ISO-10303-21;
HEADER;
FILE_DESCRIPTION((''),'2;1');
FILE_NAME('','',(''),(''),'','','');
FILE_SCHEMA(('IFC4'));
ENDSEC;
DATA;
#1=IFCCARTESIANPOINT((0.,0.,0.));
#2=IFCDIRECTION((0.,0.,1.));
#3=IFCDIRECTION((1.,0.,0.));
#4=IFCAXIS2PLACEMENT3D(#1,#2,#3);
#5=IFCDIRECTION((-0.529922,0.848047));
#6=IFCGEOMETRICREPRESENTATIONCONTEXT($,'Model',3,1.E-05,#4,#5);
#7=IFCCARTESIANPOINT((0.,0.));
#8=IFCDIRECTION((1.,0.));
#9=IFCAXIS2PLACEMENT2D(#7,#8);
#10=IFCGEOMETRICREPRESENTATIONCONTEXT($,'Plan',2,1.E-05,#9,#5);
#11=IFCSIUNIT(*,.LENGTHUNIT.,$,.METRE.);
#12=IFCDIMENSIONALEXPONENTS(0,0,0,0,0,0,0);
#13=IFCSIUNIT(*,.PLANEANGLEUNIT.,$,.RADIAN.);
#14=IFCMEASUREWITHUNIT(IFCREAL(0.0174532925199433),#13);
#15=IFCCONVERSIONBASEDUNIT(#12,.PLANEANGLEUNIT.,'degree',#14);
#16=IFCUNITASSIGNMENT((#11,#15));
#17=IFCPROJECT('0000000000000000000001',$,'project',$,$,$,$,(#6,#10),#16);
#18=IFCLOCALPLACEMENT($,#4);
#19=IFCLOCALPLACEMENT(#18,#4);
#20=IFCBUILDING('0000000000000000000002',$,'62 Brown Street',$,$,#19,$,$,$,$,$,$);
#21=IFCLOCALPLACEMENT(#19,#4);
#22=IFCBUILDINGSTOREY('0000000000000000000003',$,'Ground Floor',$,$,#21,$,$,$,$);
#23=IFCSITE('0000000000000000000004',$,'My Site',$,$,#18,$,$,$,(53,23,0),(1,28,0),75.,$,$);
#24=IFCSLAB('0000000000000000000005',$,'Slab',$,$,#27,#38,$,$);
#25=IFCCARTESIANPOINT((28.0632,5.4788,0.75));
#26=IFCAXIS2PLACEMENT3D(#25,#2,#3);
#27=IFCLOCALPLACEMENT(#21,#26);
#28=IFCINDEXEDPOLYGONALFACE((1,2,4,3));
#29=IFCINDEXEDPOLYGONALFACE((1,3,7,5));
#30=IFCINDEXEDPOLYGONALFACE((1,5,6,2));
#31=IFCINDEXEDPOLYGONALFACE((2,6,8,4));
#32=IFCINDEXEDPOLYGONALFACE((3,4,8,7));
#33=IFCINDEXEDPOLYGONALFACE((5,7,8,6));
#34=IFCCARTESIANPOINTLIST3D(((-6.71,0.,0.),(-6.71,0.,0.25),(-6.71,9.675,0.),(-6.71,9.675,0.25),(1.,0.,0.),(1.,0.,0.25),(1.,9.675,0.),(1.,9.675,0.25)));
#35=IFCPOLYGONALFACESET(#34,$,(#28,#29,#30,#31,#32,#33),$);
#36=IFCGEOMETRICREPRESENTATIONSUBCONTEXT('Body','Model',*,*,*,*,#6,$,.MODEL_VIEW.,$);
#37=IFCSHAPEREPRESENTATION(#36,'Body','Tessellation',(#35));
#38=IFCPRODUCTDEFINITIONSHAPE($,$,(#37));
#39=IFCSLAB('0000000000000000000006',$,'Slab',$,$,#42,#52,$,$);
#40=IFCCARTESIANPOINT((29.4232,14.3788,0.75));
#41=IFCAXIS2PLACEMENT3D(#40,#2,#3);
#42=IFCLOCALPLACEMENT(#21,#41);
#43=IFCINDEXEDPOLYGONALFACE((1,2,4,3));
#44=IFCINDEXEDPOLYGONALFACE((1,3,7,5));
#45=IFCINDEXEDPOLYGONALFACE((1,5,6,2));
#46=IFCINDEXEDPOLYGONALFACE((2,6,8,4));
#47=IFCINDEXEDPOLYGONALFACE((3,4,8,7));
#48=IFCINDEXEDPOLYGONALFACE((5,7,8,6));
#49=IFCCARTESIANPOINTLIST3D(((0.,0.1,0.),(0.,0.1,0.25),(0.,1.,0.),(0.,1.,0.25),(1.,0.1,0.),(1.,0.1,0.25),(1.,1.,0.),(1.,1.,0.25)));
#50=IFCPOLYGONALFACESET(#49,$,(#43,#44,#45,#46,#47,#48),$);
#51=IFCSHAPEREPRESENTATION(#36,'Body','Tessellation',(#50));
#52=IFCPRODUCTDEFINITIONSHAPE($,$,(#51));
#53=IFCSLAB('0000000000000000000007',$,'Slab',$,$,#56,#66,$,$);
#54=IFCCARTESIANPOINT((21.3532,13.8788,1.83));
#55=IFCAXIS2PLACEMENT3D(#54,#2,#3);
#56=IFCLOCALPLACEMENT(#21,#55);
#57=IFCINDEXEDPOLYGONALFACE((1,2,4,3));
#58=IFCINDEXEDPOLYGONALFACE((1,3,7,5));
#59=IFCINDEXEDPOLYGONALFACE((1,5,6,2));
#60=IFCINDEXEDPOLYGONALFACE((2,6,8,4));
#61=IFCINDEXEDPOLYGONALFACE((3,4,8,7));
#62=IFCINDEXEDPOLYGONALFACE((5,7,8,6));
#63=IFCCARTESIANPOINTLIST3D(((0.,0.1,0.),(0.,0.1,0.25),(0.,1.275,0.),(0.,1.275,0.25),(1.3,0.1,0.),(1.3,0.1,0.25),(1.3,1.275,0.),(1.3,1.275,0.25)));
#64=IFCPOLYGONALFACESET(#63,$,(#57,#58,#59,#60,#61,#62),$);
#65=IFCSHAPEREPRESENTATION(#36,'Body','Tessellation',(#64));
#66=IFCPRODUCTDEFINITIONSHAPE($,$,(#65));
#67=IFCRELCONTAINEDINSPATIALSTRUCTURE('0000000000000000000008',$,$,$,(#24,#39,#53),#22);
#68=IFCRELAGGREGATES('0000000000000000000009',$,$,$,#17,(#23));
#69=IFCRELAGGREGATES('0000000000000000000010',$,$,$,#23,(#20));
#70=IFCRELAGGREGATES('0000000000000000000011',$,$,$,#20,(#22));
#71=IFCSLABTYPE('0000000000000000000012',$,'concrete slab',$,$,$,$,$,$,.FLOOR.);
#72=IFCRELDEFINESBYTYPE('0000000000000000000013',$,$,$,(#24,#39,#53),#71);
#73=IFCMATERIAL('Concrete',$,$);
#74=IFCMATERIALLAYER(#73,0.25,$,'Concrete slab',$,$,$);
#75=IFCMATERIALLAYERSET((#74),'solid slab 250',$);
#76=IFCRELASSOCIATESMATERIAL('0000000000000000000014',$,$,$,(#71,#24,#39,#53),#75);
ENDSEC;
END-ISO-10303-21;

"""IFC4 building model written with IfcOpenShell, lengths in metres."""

from ifc_helpers import new_model, entity, si_unit, converted_unit, direction, frame, origin_with_axes, origin_2d_with_axis, place, context, subcontext, project, spatial, line, indexed_curve, outline, extrude, material, layer, layer_set, layer_usage, type_object, element, save


model = new_model("IFC4")

# Units and contexts
model_context = context("Model", 3, precision=1e-05, world=origin_with_axes(), true_north=direction((-0.529922, 0.848047)))
plan_context = context("Plan", 2, precision=1e-05, world=origin_2d_with_axis(), true_north=direction((-0.529922, 0.848047)))
body_context = subcontext(model_context, "Body", "Model", "MODEL_VIEW")
ifc_project = project(units=[si_unit("LENGTHUNIT", "METRE"), converted_unit("PLANEANGLEUNIT", "degree", entity("IfcReal", 0.0174532925199433), si_unit("PLANEANGLEUNIT", "RADIAN"), dimensions=[0, 0, 0, 0, 0, 0, 0])], contexts=[model_context, plan_context])

# Site, building, storey
site_placement = place(None, origin_with_axes())
site = spatial("IfcSite", under=ifc_project, at=site_placement, Name="My Site", RefLatitude=(53, 23, 0), RefLongitude=(1, 28, 0), RefElevation=75.0)
building_placement = place(site_placement, origin_with_axes())
building = spatial("IfcBuilding", under=site, at=building_placement, Name="62 Brown Street")
storey_placement = place(building_placement, origin_with_axes())
storey = spatial("IfcBuildingStorey", under=building, at=storey_placement, Name="Ground Floor")

# Shared definitions
ifc_material_1 = material(Name="Concrete")

# Slabs
ifc_layer_1 = layer(ifc_material_1, 0.25, Name="Concrete slab")
ifc_layer_set_1 = layer_set([ifc_layer_1], Name="solid slab 250")
slab_type = type_object("IfcSlabType", Name="concrete slab", PredefinedType="FLOOR", material=ifc_layer_set_1)
ifc_layer_usage_1 = layer_usage(ifc_layer_set_1, "AXIS3", "POSITIVE", 0.0)
slab_1_placement = place(storey_placement, frame((28.0632, 5.4788, 0.75), z_axis=(0.0, 0.0, 1.0), x_axis=(1.0, 0.0, 0.0)))
element("IfcSlab", 1, at=slab_1_placement, inside=storey, type_object=slab_type, material=ifc_layer_usage_1, Name="Slab", context=body_context, shape_type="SweptSolid", body=[
    extrude(outline(indexed_curve([(-6.71, 0.0), (-6.71, 9.675), (1.0, 9.675), (1.0, 0.0), (-6.71, 0.0)])), None, (0.0, 0.0, 1.0), 0.25),
])
ifc_layer_usage_2 = layer_usage(ifc_layer_set_1, "AXIS3", "POSITIVE", 0.0)
slab_2_placement = place(storey_placement, frame((29.4232, 14.3788, 0.75), z_axis=(0.0, 0.0, 1.0), x_axis=(1.0, 0.0, 0.0)))
element("IfcSlab", 2, at=slab_2_placement, inside=storey, type_object=slab_type, material=ifc_layer_usage_2, Name="Slab", context=body_context, shape_type="SweptSolid", body=[
    extrude(outline(indexed_curve([(1.0, 1.0), (1.0, 0.1), (0.0, 0.1), (0.0, 1.0)], segments=[line(3, 2), line(2, 1), line(1, 4), line(4, 3)], self_intersect=False)), None, (0.0, 0.0, 1.0), 0.25),
])
ifc_layer_usage_3 = layer_usage(ifc_layer_set_1, "AXIS3", "POSITIVE", 0.0)
slab_3_placement = place(storey_placement, frame((21.3532, 13.8788, 1.83), z_axis=(0.0, 0.0, 1.0), x_axis=(1.0, 0.0, 0.0)))
element("IfcSlab", 3, at=slab_3_placement, inside=storey, type_object=slab_type, material=ifc_layer_usage_3, Name="Slab", context=body_context, shape_type="SweptSolid", body=[
    extrude(outline(indexed_curve([(0.0, 0.1), (1.3, 0.1), (1.3, 1.275), (0.0, 1.275), (0.0, 0.1)])), None, (0.0, 0.0, 1.0), 0.25),
])

save(model, "model.ifc")
